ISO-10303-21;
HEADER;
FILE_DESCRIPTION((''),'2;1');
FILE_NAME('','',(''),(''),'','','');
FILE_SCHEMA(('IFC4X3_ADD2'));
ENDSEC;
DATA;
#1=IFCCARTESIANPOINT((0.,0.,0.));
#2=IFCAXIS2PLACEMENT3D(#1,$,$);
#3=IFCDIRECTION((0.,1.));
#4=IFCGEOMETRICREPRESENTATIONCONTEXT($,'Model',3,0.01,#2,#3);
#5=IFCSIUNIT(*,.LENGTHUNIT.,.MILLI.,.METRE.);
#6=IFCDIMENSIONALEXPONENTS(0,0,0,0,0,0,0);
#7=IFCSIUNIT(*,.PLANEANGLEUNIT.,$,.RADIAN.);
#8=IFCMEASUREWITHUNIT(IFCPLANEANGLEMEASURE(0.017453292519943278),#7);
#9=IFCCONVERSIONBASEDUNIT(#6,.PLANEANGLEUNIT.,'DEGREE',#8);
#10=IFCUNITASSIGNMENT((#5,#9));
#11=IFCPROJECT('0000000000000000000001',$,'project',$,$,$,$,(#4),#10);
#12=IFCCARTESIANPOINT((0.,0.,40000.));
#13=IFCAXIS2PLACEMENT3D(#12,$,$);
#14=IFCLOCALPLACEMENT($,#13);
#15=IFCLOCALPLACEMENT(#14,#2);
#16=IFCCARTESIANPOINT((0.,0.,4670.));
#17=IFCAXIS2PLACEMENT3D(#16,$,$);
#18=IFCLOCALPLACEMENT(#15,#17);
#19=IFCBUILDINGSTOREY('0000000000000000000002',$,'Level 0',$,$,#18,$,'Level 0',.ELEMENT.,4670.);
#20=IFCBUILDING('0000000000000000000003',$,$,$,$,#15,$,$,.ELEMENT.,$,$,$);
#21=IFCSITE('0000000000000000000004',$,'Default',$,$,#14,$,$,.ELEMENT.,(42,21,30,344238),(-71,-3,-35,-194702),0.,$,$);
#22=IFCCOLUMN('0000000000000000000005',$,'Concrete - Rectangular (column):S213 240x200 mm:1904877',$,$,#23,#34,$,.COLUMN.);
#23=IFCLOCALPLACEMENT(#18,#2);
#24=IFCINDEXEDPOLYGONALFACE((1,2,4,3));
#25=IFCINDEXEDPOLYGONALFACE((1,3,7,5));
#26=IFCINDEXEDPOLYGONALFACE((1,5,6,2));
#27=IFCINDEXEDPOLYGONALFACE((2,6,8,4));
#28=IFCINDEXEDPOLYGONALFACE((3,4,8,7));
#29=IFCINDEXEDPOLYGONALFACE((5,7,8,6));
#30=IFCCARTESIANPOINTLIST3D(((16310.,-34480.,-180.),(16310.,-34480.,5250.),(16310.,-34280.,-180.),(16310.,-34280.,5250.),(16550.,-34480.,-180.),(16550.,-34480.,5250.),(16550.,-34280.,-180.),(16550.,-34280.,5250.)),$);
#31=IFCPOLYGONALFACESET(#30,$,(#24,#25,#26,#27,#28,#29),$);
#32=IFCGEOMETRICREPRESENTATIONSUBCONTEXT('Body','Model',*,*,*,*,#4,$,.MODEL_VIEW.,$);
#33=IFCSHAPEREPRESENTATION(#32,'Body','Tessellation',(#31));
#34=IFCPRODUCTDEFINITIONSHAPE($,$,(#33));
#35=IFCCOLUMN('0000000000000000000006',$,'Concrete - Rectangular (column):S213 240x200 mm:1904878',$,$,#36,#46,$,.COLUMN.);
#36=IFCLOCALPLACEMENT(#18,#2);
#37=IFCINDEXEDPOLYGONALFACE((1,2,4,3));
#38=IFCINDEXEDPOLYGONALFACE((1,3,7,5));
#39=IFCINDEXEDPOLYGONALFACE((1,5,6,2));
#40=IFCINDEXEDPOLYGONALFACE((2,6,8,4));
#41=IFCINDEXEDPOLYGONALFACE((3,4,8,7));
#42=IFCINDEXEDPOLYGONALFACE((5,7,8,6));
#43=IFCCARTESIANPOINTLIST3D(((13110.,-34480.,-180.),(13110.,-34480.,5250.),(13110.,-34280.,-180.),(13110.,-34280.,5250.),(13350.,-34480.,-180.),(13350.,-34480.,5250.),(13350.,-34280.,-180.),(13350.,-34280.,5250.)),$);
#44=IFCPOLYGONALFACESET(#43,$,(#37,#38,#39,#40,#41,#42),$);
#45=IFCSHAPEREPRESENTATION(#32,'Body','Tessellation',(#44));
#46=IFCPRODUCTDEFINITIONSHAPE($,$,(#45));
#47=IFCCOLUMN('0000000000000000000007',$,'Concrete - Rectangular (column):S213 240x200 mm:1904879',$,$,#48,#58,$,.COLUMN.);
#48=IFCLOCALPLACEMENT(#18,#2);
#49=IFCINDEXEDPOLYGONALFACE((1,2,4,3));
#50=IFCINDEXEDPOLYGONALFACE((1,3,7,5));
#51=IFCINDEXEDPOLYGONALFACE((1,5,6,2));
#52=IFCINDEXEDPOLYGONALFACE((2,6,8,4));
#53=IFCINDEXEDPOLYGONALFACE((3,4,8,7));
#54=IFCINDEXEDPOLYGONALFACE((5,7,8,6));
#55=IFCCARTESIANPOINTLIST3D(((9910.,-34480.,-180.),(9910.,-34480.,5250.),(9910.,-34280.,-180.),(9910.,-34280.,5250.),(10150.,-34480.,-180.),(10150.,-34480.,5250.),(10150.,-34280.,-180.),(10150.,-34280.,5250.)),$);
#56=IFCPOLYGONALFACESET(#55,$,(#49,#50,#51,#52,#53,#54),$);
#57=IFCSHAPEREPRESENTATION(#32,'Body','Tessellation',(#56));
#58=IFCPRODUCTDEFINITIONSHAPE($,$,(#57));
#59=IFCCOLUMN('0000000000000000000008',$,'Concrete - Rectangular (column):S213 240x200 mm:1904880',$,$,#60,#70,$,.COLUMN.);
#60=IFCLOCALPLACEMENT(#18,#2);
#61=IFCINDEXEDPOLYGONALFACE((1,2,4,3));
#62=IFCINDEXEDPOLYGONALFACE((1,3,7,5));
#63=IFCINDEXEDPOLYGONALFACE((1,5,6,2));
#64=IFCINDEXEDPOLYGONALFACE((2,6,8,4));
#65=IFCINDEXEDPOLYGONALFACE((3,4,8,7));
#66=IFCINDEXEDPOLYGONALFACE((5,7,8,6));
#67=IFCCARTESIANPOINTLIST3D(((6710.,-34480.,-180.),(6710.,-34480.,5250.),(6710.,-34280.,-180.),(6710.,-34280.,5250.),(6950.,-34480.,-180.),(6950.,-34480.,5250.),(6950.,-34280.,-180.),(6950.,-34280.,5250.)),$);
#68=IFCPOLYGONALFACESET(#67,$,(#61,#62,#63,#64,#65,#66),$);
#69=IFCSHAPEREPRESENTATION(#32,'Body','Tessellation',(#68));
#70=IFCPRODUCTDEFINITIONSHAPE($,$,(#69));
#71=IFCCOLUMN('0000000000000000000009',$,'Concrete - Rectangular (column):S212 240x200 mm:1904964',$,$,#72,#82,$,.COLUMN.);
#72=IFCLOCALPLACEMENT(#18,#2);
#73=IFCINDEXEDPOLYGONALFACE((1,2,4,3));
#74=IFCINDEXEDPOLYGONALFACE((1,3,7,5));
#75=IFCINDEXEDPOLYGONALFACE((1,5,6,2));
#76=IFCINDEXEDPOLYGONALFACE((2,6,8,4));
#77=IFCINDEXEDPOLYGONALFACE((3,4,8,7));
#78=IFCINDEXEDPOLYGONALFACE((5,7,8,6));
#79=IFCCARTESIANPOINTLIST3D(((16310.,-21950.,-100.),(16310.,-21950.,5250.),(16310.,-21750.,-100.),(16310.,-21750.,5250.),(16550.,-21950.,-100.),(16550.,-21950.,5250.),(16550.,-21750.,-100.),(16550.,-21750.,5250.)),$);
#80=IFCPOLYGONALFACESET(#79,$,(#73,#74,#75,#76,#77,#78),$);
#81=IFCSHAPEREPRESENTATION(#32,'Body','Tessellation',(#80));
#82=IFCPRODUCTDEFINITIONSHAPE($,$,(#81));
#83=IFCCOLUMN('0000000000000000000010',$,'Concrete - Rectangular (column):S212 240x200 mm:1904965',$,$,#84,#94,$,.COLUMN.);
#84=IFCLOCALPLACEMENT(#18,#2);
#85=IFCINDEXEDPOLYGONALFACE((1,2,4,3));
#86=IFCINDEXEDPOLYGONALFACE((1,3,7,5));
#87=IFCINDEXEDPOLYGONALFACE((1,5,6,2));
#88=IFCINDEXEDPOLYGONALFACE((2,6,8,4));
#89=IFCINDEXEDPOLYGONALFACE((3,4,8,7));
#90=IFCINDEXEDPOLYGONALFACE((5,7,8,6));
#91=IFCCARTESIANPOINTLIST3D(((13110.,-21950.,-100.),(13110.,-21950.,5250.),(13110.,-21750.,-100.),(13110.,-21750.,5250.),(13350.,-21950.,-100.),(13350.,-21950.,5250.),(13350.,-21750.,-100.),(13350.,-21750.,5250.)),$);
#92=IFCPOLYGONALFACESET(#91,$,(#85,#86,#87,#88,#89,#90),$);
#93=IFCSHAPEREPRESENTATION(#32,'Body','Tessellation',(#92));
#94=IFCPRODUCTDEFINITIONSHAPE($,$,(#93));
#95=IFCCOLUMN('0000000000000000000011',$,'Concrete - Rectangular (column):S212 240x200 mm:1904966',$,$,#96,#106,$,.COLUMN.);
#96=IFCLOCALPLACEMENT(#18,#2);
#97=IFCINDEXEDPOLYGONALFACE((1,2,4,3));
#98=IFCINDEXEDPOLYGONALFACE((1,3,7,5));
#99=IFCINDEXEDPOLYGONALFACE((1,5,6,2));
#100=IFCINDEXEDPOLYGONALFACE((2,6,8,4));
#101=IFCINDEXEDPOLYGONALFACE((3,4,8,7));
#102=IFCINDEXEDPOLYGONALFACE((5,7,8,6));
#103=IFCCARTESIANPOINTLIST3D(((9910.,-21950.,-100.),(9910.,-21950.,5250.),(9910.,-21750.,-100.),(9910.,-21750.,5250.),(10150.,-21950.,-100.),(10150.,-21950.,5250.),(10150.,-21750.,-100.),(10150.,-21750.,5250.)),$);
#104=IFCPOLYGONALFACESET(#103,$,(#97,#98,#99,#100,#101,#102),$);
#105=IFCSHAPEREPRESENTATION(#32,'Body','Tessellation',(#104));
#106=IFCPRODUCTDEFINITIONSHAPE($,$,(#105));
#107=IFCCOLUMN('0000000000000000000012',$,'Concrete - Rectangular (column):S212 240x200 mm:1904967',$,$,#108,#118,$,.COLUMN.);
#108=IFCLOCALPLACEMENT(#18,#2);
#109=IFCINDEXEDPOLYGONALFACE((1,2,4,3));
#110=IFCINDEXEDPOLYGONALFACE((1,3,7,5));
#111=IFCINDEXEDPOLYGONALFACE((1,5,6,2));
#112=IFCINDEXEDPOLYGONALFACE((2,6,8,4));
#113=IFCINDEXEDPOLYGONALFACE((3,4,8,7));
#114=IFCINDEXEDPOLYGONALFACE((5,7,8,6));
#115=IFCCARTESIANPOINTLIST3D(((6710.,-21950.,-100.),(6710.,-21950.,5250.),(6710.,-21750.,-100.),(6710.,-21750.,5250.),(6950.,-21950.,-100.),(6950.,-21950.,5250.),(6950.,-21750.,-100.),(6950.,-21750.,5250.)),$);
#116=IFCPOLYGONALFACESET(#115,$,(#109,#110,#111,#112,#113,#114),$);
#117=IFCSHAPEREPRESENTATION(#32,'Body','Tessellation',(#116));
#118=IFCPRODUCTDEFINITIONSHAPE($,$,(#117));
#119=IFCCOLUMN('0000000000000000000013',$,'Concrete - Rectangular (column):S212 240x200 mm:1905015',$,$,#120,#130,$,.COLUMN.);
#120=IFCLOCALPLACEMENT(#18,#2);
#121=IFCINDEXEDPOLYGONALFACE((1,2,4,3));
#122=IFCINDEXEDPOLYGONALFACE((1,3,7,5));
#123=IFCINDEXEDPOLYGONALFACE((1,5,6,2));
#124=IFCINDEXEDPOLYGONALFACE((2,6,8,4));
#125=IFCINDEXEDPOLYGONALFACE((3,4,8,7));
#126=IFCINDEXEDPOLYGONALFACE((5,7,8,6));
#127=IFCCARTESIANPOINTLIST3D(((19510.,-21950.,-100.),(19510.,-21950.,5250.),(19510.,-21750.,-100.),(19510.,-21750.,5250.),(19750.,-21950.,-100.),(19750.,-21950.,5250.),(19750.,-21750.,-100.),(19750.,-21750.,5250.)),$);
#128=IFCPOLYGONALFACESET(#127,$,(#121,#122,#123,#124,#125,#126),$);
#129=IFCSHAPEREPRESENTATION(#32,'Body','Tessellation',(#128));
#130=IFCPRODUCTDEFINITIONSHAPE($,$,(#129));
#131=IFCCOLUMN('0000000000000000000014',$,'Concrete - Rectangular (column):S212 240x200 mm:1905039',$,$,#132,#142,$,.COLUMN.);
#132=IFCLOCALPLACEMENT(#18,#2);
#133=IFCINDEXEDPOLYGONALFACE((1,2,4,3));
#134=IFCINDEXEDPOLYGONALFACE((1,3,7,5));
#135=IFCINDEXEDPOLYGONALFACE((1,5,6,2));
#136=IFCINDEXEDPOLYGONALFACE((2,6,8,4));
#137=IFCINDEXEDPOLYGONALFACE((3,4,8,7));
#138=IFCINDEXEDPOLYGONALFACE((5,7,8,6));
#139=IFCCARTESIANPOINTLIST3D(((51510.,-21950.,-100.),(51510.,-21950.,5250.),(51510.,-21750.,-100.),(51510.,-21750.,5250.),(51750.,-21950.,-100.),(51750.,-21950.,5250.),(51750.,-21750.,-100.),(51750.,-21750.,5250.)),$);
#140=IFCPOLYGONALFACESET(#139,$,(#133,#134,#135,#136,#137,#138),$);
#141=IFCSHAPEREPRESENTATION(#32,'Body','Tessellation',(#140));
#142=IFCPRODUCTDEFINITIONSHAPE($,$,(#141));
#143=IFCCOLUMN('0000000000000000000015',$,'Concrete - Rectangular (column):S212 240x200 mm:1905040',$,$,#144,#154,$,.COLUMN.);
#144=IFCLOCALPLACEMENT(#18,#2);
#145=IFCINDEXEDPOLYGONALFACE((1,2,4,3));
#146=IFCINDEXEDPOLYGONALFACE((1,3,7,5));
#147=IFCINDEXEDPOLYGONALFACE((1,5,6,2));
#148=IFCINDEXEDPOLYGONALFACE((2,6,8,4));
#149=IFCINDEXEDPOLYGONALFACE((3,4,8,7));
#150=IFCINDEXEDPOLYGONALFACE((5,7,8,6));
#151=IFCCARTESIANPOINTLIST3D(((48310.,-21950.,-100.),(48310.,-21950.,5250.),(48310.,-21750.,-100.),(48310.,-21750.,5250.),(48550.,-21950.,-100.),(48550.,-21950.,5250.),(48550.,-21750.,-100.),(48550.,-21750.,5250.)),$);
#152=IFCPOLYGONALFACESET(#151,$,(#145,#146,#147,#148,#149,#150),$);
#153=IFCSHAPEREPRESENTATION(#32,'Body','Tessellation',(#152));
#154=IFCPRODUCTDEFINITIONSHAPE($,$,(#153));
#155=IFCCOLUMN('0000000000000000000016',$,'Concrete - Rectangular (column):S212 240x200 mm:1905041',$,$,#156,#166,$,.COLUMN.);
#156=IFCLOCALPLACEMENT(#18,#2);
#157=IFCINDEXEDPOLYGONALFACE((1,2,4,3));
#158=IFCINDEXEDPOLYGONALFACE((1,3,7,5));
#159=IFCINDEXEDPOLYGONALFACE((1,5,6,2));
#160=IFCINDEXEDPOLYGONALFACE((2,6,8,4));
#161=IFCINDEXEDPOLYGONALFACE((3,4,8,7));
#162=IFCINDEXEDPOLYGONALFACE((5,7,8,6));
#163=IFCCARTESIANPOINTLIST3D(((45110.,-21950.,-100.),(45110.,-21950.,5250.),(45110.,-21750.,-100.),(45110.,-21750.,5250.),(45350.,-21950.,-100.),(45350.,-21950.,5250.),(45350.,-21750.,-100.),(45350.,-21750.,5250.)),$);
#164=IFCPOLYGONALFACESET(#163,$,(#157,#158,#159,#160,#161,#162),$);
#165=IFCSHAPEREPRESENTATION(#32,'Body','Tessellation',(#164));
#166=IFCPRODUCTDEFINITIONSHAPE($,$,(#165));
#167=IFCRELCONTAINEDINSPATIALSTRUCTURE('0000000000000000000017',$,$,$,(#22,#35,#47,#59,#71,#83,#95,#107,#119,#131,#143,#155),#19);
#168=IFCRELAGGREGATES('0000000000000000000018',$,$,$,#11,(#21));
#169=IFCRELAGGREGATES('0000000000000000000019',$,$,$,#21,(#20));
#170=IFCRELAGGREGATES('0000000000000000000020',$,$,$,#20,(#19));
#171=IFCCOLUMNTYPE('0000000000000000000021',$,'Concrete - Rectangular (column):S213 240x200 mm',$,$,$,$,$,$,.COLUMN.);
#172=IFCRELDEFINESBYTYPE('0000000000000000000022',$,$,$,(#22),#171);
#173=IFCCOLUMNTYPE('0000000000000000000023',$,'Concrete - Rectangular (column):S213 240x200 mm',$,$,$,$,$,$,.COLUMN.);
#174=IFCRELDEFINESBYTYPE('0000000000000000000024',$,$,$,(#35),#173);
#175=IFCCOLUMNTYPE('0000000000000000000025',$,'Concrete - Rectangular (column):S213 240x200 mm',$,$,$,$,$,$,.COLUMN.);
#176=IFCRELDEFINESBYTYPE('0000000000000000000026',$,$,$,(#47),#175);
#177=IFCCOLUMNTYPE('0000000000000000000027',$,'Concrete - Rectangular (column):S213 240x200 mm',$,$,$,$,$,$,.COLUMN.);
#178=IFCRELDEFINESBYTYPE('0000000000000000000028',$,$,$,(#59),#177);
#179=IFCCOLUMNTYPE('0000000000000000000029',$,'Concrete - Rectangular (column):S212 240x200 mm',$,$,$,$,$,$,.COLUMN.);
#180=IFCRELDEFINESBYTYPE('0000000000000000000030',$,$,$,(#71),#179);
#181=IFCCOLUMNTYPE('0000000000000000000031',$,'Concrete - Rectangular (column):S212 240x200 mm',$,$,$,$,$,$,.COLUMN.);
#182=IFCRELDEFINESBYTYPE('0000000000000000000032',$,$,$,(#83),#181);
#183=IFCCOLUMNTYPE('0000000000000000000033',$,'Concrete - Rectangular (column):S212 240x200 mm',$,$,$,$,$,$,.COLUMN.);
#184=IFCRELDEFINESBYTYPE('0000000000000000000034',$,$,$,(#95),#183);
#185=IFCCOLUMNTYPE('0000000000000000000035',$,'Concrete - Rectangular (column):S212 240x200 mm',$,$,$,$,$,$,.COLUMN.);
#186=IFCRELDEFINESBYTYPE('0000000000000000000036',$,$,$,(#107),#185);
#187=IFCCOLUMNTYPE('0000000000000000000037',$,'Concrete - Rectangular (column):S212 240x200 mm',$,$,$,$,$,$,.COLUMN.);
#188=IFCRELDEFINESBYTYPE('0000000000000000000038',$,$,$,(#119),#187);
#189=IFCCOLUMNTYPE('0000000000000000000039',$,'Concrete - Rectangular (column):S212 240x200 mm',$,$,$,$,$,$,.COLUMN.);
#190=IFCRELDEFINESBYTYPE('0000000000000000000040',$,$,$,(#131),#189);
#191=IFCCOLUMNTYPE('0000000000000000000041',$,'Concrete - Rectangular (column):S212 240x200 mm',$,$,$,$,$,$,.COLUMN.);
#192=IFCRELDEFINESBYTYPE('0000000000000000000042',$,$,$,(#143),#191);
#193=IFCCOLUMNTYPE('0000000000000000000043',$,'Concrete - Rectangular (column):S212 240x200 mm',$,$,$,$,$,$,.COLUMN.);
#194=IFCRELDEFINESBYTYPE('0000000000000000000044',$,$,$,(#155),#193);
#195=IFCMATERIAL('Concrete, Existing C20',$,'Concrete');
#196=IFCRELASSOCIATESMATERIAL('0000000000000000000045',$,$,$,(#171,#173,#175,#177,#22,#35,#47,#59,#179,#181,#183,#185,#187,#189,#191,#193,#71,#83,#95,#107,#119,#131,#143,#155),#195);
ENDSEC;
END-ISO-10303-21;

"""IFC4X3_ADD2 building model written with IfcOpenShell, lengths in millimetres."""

from ifc_helpers import new_model, entity, si_unit, converted_unit, direction, frame, frame_2d, origin, origin_2d_with_axis, place, context, subcontext, project, spatial, rectangle, extrude, source, transform, mapped, material, material_profile, profile_set, profile_usage, type_object, type_shapes, element, save


model = new_model("IFC4X3_ADD2")

# Units and contexts
model_context = context("Model", 3, precision=0.01, world=origin(), true_north=direction((0.0, 1.0)))
body_context = subcontext(model_context, "Body", "Model", "MODEL_VIEW")
ifc_project = project(units=[si_unit("LENGTHUNIT", "METRE", prefix="MILLI"), converted_unit("PLANEANGLEUNIT", "DEGREE", entity("IfcPlaneAngleMeasure", 0.017453292519943278), si_unit("PLANEANGLEUNIT", "RADIAN"), dimensions=[0, 0, 0, 0, 0, 0, 0])], contexts=[model_context])

# Site, building, storey
site_placement = place(None, frame((0.0, 0.0, 40000.0)))
site = spatial("IfcSite", under=ifc_project, at=site_placement, Name="Default", CompositionType="ELEMENT", RefLatitude=(42, 21, 30, 344238), RefLongitude=(-71, -3, -35, -194702), RefElevation=0.0)
building_placement = place(site_placement, origin())
building = spatial("IfcBuilding", under=site, at=building_placement, CompositionType="ELEMENT")
storey_placement = place(building_placement, frame((0.0, 0.0, 4670.0)))
storey = spatial("IfcBuildingStorey", under=building, at=storey_placement, Name="Level 0", LongName="Level 0", CompositionType="ELEMENT", Elevation=4670.0)

# Columns
ifc_material = material(Name="Concrete, Existing C20", Category="Concrete")
ifc_material_profile_1 = material_profile(ifc_material, rectangle(XDim=200.0, YDim=240.0, at=origin_2d_with_axis()), Name="S213 240x200 mm")
ifc_profile_set_1 = profile_set([ifc_material_profile_1], Name="S213 240x200 mm")
ifc_profile_usage_1 = profile_usage(ifc_profile_set_1)
column_type_1 = type_object("IfcColumnType", Name="Concrete - Rectangular (column):S213 240x200 mm", PredefinedType="COLUMN", material=ifc_profile_set_1)
shared_shape_1 = source(origin(), body_context, "Body", "SweptSolid", [
    extrude(rectangle(XDim=200.0, YDim=240.0, at=frame_2d((0.0, 0.0), x_axis=(1.0, 0.0))), frame((16430.0, -34380.0, 4490.0), z_axis=(0.0, 0.0, 1.0), x_axis=(0.0, 1.0, 0.0)), (0.0, 0.0, 1.0), 5430.0),
])
type_shapes(column_type_1, [shared_shape_1])
column_1_placement = place(storey_placement, frame((0.0, 0.0, -4670.0)))
element("IfcColumn", 1, at=column_1_placement, inside=storey, type_object=column_type_1, material=ifc_profile_usage_1, Name="Concrete - Rectangular (column):S213 240x200 mm:1904877", PredefinedType="COLUMN", context=body_context, shape_type="MappedRepresentation", body=[
    mapped(shared_shape_1, transform((0.0, 0.0, 0.0), scale=1.0)),
])
column_type_2 = type_object("IfcColumnType", Name="Concrete - Rectangular (column):S213 240x200 mm", PredefinedType="COLUMN", material=ifc_profile_set_1)
shared_shape_2 = source(origin(), body_context, "Body", "SweptSolid", [
    extrude(rectangle(XDim=200.0, YDim=240.0, at=frame_2d((0.0, 0.0), x_axis=(1.0, 0.0))), frame((13230.0, -34380.0, 4490.0), z_axis=(0.0, 0.0, 1.0), x_axis=(0.0, 1.0, 0.0)), (0.0, 0.0, 1.0), 5430.0),
])
type_shapes(column_type_2, [shared_shape_2])
column_2_placement = place(storey_placement, frame((0.0, 0.0, -4670.0)))
element("IfcColumn", 2, at=column_2_placement, inside=storey, type_object=column_type_2, material=ifc_profile_usage_1, Name="Concrete - Rectangular (column):S213 240x200 mm:1904878", PredefinedType="COLUMN", context=body_context, shape_type="MappedRepresentation", body=[
    mapped(shared_shape_2, transform((0.0, 0.0, 0.0), scale=1.0)),
])
column_type_3 = type_object("IfcColumnType", Name="Concrete - Rectangular (column):S213 240x200 mm", PredefinedType="COLUMN", material=ifc_profile_set_1)
shared_shape_3 = source(origin(), body_context, "Body", "SweptSolid", [
    extrude(rectangle(XDim=200.0, YDim=240.0, at=frame_2d((0.0, 0.0), x_axis=(1.0, 0.0))), frame((10030.0, -34380.0, 4490.0), z_axis=(0.0, 0.0, 1.0), x_axis=(0.0, 1.0, 0.0)), (0.0, 0.0, 1.0), 5430.0),
])
type_shapes(column_type_3, [shared_shape_3])
column_3_placement = place(storey_placement, frame((0.0, 0.0, -4670.0)))
element("IfcColumn", 3, at=column_3_placement, inside=storey, type_object=column_type_3, material=ifc_profile_usage_1, Name="Concrete - Rectangular (column):S213 240x200 mm:1904879", PredefinedType="COLUMN", context=body_context, shape_type="MappedRepresentation", body=[
    mapped(shared_shape_3, transform((0.0, 0.0, 0.0), scale=1.0)),
])
column_type_4 = type_object("IfcColumnType", Name="Concrete - Rectangular (column):S213 240x200 mm", PredefinedType="COLUMN", material=ifc_profile_set_1)
shared_shape_4 = source(origin(), body_context, "Body", "SweptSolid", [
    extrude(rectangle(XDim=200.0, YDim=240.0, at=origin_2d_with_axis()), frame((6830.0, -34380.0, 4490.0), z_axis=(0.0, 0.0, 1.0), x_axis=(0.0, 1.0, 0.0)), (0.0, 0.0, 1.0), 5430.0),
])
type_shapes(column_type_4, [shared_shape_4])
column_4_placement = place(storey_placement, frame((0.0, 0.0, -4670.0)))
element("IfcColumn", 4, at=column_4_placement, inside=storey, type_object=column_type_4, material=ifc_profile_usage_1, Name="Concrete - Rectangular (column):S213 240x200 mm:1904880", PredefinedType="COLUMN", context=body_context, shape_type="MappedRepresentation", body=[
    mapped(shared_shape_4, transform((0.0, 0.0, 0.0), scale=1.0)),
])
ifc_material_profile_2 = material_profile(ifc_material, rectangle(XDim=200.0, YDim=240.0, at=frame_2d((0.0, 0.0), x_axis=(1.0, 0.0))), Name="S212 240x200 mm")
ifc_profile_set_2 = profile_set([ifc_material_profile_2], Name="S212 240x200 mm")
ifc_profile_usage_2 = profile_usage(ifc_profile_set_2)
column_type_5 = type_object("IfcColumnType", Name="Concrete - Rectangular (column):S212 240x200 mm", PredefinedType="COLUMN", material=ifc_profile_set_2)
shared_shape_5 = source(origin(), body_context, "Body", "SweptSolid", [
    extrude(rectangle(XDim=200.0, YDim=240.0, at=frame_2d((0.0, 0.0), x_axis=(1.0, 0.0))), frame((16430.0, -21850.0, 4570.0), z_axis=(0.0, 0.0, 1.0), x_axis=(0.0, 1.0, 0.0)), (0.0, 0.0, 1.0), 5350.0),
])
type_shapes(column_type_5, [shared_shape_5])
column_5_placement = place(storey_placement, frame((0.0, 0.0, -4670.0)))
element("IfcColumn", 5, at=column_5_placement, inside=storey, type_object=column_type_5, material=ifc_profile_usage_2, Name="Concrete - Rectangular (column):S212 240x200 mm:1904964", PredefinedType="COLUMN", context=body_context, shape_type="MappedRepresentation", body=[
    mapped(shared_shape_5, transform((0.0, 0.0, 0.0), scale=1.0)),
])
column_type_6 = type_object("IfcColumnType", Name="Concrete - Rectangular (column):S212 240x200 mm", PredefinedType="COLUMN", material=ifc_profile_set_2)
shared_shape_6 = source(origin(), body_context, "Body", "SweptSolid", [
    extrude(rectangle(XDim=200.0, YDim=240.0, at=frame_2d((0.0, 0.0), x_axis=(1.0, 0.0))), frame((13230.0, -21850.0, 4570.0), z_axis=(0.0, 0.0, 1.0), x_axis=(0.0, 1.0, 0.0)), (0.0, 0.0, 1.0), 5350.0),
])
type_shapes(column_type_6, [shared_shape_6])
column_6_placement = place(storey_placement, frame((0.0, 0.0, -4670.0)))
element("IfcColumn", 6, at=column_6_placement, inside=storey, type_object=column_type_6, material=ifc_profile_usage_2, Name="Concrete - Rectangular (column):S212 240x200 mm:1904965", PredefinedType="COLUMN", context=body_context, shape_type="MappedRepresentation", body=[
    mapped(shared_shape_6, transform((0.0, 0.0, 0.0), scale=1.0)),
])
column_type_7 = type_object("IfcColumnType", Name="Concrete - Rectangular (column):S212 240x200 mm", PredefinedType="COLUMN", material=ifc_profile_set_2)
shared_shape_7 = source(origin(), body_context, "Body", "SweptSolid", [
    extrude(rectangle(XDim=200.0, YDim=240.0, at=frame_2d((0.0, 0.0), x_axis=(1.0, 0.0))), frame((10030.0, -21850.0, 4570.0), z_axis=(0.0, 0.0, 1.0), x_axis=(0.0, 1.0, 0.0)), (0.0, 0.0, 1.0), 5350.0),
])
type_shapes(column_type_7, [shared_shape_7])
column_7_placement = place(storey_placement, frame((0.0, 0.0, -4670.0)))
element("IfcColumn", 7, at=column_7_placement, inside=storey, type_object=column_type_7, material=ifc_profile_usage_2, Name="Concrete - Rectangular (column):S212 240x200 mm:1904966", PredefinedType="COLUMN", context=body_context, shape_type="MappedRepresentation", body=[
    mapped(shared_shape_7, transform((0.0, 0.0, 0.0), scale=1.0)),
])
column_type_8 = type_object("IfcColumnType", Name="Concrete - Rectangular (column):S212 240x200 mm", PredefinedType="COLUMN", material=ifc_profile_set_2)
shared_shape_8 = source(origin(), body_context, "Body", "SweptSolid", [
    extrude(rectangle(XDim=200.0, YDim=240.0, at=origin_2d_with_axis()), frame((6830.0, -21850.0, 4570.0), z_axis=(0.0, 0.0, 1.0), x_axis=(0.0, 1.0, 0.0)), (0.0, 0.0, 1.0), 5350.0),
])
type_shapes(column_type_8, [shared_shape_8])
column_8_placement = place(storey_placement, frame((0.0, 0.0, -4670.0)))
element("IfcColumn", 8, at=column_8_placement, inside=storey, type_object=column_type_8, material=ifc_profile_usage_2, Name="Concrete - Rectangular (column):S212 240x200 mm:1904967", PredefinedType="COLUMN", context=body_context, shape_type="MappedRepresentation", body=[
    mapped(shared_shape_8, transform((0.0, 0.0, 0.0), scale=1.0)),
])
column_type_9 = type_object("IfcColumnType", Name="Concrete - Rectangular (column):S212 240x200 mm", PredefinedType="COLUMN", material=ifc_profile_set_2)
shared_shape_9 = source(origin(), body_context, "Body", "SweptSolid", [
    extrude(rectangle(XDim=200.0, YDim=240.0, at=frame_2d((0.0, 0.0), x_axis=(1.0, 0.0))), frame((19630.0, -21850.0, 4570.0), z_axis=(0.0, 0.0, 1.0), x_axis=(0.0, 1.0, 0.0)), (0.0, 0.0, 1.0), 5350.0),
])
type_shapes(column_type_9, [shared_shape_9])
column_9_placement = place(storey_placement, frame((0.0, 0.0, -4670.0)))
element("IfcColumn", 9, at=column_9_placement, inside=storey, type_object=column_type_9, material=ifc_profile_usage_2, Name="Concrete - Rectangular (column):S212 240x200 mm:1905015", PredefinedType="COLUMN", context=body_context, shape_type="MappedRepresentation", body=[
    mapped(shared_shape_9, transform((0.0, 0.0, 0.0), scale=1.0)),
])
column_type_10 = type_object("IfcColumnType", Name="Concrete - Rectangular (column):S212 240x200 mm", PredefinedType="COLUMN", material=ifc_profile_set_2)
shared_shape_10 = source(origin(), body_context, "Body", "SweptSolid", [
    extrude(rectangle(XDim=200.0, YDim=240.0, at=origin_2d_with_axis()), frame((51630.0, -21850.0, 4570.0), z_axis=(0.0, 0.0, 1.0), x_axis=(0.0, 1.0, 0.0)), (0.0, 0.0, 1.0), 5350.0),
])
type_shapes(column_type_10, [shared_shape_10])
column_10_placement = place(storey_placement, frame((0.0, 0.0, -4670.0)))
element("IfcColumn", 10, at=column_10_placement, inside=storey, type_object=column_type_10, material=ifc_profile_usage_2, Name="Concrete - Rectangular (column):S212 240x200 mm:1905039", PredefinedType="COLUMN", context=body_context, shape_type="MappedRepresentation", body=[
    mapped(shared_shape_10, transform((0.0, 0.0, 0.0), scale=1.0)),
])
column_type_11 = type_object("IfcColumnType", Name="Concrete - Rectangular (column):S212 240x200 mm", PredefinedType="COLUMN", material=ifc_profile_set_2)
shared_shape_11 = source(origin(), body_context, "Body", "SweptSolid", [
    extrude(rectangle(XDim=200.0, YDim=240.0, at=origin_2d_with_axis()), frame((48430.0, -21850.0, 4570.0), z_axis=(0.0, 0.0, 1.0), x_axis=(0.0, 1.0, 0.0)), (0.0, 0.0, 1.0), 5350.0),
])
type_shapes(column_type_11, [shared_shape_11])
column_11_placement = place(storey_placement, frame((0.0, 0.0, -4670.0)))
element("IfcColumn", 11, at=column_11_placement, inside=storey, type_object=column_type_11, material=ifc_profile_usage_2, Name="Concrete - Rectangular (column):S212 240x200 mm:1905040", PredefinedType="COLUMN", context=body_context, shape_type="MappedRepresentation", body=[
    mapped(shared_shape_11, transform((0.0, 0.0, 0.0), scale=1.0)),
])
column_type_12 = type_object("IfcColumnType", Name="Concrete - Rectangular (column):S212 240x200 mm", PredefinedType="COLUMN", material=ifc_profile_set_2)
shared_shape_12 = source(origin(), body_context, "Body", "SweptSolid", [
    extrude(rectangle(XDim=200.0, YDim=240.0, at=origin_2d_with_axis()), frame((45230.0, -21850.0, 4570.0), z_axis=(0.0, 0.0, 1.0), x_axis=(0.0, 1.0, 0.0)), (0.0, 0.0, 1.0), 5350.0),
])
type_shapes(column_type_12, [shared_shape_12])
column_12_placement = place(storey_placement, frame((0.0, 0.0, -4670.0)))
element("IfcColumn", 12, at=column_12_placement, inside=storey, type_object=column_type_12, material=ifc_profile_usage_2, Name="Concrete - Rectangular (column):S212 240x200 mm:1905041", PredefinedType="COLUMN", context=body_context, shape_type="MappedRepresentation", body=[
    mapped(shared_shape_12, transform((0.0, 0.0, 0.0), scale=1.0)),
])

save(model, "model.ifc")
